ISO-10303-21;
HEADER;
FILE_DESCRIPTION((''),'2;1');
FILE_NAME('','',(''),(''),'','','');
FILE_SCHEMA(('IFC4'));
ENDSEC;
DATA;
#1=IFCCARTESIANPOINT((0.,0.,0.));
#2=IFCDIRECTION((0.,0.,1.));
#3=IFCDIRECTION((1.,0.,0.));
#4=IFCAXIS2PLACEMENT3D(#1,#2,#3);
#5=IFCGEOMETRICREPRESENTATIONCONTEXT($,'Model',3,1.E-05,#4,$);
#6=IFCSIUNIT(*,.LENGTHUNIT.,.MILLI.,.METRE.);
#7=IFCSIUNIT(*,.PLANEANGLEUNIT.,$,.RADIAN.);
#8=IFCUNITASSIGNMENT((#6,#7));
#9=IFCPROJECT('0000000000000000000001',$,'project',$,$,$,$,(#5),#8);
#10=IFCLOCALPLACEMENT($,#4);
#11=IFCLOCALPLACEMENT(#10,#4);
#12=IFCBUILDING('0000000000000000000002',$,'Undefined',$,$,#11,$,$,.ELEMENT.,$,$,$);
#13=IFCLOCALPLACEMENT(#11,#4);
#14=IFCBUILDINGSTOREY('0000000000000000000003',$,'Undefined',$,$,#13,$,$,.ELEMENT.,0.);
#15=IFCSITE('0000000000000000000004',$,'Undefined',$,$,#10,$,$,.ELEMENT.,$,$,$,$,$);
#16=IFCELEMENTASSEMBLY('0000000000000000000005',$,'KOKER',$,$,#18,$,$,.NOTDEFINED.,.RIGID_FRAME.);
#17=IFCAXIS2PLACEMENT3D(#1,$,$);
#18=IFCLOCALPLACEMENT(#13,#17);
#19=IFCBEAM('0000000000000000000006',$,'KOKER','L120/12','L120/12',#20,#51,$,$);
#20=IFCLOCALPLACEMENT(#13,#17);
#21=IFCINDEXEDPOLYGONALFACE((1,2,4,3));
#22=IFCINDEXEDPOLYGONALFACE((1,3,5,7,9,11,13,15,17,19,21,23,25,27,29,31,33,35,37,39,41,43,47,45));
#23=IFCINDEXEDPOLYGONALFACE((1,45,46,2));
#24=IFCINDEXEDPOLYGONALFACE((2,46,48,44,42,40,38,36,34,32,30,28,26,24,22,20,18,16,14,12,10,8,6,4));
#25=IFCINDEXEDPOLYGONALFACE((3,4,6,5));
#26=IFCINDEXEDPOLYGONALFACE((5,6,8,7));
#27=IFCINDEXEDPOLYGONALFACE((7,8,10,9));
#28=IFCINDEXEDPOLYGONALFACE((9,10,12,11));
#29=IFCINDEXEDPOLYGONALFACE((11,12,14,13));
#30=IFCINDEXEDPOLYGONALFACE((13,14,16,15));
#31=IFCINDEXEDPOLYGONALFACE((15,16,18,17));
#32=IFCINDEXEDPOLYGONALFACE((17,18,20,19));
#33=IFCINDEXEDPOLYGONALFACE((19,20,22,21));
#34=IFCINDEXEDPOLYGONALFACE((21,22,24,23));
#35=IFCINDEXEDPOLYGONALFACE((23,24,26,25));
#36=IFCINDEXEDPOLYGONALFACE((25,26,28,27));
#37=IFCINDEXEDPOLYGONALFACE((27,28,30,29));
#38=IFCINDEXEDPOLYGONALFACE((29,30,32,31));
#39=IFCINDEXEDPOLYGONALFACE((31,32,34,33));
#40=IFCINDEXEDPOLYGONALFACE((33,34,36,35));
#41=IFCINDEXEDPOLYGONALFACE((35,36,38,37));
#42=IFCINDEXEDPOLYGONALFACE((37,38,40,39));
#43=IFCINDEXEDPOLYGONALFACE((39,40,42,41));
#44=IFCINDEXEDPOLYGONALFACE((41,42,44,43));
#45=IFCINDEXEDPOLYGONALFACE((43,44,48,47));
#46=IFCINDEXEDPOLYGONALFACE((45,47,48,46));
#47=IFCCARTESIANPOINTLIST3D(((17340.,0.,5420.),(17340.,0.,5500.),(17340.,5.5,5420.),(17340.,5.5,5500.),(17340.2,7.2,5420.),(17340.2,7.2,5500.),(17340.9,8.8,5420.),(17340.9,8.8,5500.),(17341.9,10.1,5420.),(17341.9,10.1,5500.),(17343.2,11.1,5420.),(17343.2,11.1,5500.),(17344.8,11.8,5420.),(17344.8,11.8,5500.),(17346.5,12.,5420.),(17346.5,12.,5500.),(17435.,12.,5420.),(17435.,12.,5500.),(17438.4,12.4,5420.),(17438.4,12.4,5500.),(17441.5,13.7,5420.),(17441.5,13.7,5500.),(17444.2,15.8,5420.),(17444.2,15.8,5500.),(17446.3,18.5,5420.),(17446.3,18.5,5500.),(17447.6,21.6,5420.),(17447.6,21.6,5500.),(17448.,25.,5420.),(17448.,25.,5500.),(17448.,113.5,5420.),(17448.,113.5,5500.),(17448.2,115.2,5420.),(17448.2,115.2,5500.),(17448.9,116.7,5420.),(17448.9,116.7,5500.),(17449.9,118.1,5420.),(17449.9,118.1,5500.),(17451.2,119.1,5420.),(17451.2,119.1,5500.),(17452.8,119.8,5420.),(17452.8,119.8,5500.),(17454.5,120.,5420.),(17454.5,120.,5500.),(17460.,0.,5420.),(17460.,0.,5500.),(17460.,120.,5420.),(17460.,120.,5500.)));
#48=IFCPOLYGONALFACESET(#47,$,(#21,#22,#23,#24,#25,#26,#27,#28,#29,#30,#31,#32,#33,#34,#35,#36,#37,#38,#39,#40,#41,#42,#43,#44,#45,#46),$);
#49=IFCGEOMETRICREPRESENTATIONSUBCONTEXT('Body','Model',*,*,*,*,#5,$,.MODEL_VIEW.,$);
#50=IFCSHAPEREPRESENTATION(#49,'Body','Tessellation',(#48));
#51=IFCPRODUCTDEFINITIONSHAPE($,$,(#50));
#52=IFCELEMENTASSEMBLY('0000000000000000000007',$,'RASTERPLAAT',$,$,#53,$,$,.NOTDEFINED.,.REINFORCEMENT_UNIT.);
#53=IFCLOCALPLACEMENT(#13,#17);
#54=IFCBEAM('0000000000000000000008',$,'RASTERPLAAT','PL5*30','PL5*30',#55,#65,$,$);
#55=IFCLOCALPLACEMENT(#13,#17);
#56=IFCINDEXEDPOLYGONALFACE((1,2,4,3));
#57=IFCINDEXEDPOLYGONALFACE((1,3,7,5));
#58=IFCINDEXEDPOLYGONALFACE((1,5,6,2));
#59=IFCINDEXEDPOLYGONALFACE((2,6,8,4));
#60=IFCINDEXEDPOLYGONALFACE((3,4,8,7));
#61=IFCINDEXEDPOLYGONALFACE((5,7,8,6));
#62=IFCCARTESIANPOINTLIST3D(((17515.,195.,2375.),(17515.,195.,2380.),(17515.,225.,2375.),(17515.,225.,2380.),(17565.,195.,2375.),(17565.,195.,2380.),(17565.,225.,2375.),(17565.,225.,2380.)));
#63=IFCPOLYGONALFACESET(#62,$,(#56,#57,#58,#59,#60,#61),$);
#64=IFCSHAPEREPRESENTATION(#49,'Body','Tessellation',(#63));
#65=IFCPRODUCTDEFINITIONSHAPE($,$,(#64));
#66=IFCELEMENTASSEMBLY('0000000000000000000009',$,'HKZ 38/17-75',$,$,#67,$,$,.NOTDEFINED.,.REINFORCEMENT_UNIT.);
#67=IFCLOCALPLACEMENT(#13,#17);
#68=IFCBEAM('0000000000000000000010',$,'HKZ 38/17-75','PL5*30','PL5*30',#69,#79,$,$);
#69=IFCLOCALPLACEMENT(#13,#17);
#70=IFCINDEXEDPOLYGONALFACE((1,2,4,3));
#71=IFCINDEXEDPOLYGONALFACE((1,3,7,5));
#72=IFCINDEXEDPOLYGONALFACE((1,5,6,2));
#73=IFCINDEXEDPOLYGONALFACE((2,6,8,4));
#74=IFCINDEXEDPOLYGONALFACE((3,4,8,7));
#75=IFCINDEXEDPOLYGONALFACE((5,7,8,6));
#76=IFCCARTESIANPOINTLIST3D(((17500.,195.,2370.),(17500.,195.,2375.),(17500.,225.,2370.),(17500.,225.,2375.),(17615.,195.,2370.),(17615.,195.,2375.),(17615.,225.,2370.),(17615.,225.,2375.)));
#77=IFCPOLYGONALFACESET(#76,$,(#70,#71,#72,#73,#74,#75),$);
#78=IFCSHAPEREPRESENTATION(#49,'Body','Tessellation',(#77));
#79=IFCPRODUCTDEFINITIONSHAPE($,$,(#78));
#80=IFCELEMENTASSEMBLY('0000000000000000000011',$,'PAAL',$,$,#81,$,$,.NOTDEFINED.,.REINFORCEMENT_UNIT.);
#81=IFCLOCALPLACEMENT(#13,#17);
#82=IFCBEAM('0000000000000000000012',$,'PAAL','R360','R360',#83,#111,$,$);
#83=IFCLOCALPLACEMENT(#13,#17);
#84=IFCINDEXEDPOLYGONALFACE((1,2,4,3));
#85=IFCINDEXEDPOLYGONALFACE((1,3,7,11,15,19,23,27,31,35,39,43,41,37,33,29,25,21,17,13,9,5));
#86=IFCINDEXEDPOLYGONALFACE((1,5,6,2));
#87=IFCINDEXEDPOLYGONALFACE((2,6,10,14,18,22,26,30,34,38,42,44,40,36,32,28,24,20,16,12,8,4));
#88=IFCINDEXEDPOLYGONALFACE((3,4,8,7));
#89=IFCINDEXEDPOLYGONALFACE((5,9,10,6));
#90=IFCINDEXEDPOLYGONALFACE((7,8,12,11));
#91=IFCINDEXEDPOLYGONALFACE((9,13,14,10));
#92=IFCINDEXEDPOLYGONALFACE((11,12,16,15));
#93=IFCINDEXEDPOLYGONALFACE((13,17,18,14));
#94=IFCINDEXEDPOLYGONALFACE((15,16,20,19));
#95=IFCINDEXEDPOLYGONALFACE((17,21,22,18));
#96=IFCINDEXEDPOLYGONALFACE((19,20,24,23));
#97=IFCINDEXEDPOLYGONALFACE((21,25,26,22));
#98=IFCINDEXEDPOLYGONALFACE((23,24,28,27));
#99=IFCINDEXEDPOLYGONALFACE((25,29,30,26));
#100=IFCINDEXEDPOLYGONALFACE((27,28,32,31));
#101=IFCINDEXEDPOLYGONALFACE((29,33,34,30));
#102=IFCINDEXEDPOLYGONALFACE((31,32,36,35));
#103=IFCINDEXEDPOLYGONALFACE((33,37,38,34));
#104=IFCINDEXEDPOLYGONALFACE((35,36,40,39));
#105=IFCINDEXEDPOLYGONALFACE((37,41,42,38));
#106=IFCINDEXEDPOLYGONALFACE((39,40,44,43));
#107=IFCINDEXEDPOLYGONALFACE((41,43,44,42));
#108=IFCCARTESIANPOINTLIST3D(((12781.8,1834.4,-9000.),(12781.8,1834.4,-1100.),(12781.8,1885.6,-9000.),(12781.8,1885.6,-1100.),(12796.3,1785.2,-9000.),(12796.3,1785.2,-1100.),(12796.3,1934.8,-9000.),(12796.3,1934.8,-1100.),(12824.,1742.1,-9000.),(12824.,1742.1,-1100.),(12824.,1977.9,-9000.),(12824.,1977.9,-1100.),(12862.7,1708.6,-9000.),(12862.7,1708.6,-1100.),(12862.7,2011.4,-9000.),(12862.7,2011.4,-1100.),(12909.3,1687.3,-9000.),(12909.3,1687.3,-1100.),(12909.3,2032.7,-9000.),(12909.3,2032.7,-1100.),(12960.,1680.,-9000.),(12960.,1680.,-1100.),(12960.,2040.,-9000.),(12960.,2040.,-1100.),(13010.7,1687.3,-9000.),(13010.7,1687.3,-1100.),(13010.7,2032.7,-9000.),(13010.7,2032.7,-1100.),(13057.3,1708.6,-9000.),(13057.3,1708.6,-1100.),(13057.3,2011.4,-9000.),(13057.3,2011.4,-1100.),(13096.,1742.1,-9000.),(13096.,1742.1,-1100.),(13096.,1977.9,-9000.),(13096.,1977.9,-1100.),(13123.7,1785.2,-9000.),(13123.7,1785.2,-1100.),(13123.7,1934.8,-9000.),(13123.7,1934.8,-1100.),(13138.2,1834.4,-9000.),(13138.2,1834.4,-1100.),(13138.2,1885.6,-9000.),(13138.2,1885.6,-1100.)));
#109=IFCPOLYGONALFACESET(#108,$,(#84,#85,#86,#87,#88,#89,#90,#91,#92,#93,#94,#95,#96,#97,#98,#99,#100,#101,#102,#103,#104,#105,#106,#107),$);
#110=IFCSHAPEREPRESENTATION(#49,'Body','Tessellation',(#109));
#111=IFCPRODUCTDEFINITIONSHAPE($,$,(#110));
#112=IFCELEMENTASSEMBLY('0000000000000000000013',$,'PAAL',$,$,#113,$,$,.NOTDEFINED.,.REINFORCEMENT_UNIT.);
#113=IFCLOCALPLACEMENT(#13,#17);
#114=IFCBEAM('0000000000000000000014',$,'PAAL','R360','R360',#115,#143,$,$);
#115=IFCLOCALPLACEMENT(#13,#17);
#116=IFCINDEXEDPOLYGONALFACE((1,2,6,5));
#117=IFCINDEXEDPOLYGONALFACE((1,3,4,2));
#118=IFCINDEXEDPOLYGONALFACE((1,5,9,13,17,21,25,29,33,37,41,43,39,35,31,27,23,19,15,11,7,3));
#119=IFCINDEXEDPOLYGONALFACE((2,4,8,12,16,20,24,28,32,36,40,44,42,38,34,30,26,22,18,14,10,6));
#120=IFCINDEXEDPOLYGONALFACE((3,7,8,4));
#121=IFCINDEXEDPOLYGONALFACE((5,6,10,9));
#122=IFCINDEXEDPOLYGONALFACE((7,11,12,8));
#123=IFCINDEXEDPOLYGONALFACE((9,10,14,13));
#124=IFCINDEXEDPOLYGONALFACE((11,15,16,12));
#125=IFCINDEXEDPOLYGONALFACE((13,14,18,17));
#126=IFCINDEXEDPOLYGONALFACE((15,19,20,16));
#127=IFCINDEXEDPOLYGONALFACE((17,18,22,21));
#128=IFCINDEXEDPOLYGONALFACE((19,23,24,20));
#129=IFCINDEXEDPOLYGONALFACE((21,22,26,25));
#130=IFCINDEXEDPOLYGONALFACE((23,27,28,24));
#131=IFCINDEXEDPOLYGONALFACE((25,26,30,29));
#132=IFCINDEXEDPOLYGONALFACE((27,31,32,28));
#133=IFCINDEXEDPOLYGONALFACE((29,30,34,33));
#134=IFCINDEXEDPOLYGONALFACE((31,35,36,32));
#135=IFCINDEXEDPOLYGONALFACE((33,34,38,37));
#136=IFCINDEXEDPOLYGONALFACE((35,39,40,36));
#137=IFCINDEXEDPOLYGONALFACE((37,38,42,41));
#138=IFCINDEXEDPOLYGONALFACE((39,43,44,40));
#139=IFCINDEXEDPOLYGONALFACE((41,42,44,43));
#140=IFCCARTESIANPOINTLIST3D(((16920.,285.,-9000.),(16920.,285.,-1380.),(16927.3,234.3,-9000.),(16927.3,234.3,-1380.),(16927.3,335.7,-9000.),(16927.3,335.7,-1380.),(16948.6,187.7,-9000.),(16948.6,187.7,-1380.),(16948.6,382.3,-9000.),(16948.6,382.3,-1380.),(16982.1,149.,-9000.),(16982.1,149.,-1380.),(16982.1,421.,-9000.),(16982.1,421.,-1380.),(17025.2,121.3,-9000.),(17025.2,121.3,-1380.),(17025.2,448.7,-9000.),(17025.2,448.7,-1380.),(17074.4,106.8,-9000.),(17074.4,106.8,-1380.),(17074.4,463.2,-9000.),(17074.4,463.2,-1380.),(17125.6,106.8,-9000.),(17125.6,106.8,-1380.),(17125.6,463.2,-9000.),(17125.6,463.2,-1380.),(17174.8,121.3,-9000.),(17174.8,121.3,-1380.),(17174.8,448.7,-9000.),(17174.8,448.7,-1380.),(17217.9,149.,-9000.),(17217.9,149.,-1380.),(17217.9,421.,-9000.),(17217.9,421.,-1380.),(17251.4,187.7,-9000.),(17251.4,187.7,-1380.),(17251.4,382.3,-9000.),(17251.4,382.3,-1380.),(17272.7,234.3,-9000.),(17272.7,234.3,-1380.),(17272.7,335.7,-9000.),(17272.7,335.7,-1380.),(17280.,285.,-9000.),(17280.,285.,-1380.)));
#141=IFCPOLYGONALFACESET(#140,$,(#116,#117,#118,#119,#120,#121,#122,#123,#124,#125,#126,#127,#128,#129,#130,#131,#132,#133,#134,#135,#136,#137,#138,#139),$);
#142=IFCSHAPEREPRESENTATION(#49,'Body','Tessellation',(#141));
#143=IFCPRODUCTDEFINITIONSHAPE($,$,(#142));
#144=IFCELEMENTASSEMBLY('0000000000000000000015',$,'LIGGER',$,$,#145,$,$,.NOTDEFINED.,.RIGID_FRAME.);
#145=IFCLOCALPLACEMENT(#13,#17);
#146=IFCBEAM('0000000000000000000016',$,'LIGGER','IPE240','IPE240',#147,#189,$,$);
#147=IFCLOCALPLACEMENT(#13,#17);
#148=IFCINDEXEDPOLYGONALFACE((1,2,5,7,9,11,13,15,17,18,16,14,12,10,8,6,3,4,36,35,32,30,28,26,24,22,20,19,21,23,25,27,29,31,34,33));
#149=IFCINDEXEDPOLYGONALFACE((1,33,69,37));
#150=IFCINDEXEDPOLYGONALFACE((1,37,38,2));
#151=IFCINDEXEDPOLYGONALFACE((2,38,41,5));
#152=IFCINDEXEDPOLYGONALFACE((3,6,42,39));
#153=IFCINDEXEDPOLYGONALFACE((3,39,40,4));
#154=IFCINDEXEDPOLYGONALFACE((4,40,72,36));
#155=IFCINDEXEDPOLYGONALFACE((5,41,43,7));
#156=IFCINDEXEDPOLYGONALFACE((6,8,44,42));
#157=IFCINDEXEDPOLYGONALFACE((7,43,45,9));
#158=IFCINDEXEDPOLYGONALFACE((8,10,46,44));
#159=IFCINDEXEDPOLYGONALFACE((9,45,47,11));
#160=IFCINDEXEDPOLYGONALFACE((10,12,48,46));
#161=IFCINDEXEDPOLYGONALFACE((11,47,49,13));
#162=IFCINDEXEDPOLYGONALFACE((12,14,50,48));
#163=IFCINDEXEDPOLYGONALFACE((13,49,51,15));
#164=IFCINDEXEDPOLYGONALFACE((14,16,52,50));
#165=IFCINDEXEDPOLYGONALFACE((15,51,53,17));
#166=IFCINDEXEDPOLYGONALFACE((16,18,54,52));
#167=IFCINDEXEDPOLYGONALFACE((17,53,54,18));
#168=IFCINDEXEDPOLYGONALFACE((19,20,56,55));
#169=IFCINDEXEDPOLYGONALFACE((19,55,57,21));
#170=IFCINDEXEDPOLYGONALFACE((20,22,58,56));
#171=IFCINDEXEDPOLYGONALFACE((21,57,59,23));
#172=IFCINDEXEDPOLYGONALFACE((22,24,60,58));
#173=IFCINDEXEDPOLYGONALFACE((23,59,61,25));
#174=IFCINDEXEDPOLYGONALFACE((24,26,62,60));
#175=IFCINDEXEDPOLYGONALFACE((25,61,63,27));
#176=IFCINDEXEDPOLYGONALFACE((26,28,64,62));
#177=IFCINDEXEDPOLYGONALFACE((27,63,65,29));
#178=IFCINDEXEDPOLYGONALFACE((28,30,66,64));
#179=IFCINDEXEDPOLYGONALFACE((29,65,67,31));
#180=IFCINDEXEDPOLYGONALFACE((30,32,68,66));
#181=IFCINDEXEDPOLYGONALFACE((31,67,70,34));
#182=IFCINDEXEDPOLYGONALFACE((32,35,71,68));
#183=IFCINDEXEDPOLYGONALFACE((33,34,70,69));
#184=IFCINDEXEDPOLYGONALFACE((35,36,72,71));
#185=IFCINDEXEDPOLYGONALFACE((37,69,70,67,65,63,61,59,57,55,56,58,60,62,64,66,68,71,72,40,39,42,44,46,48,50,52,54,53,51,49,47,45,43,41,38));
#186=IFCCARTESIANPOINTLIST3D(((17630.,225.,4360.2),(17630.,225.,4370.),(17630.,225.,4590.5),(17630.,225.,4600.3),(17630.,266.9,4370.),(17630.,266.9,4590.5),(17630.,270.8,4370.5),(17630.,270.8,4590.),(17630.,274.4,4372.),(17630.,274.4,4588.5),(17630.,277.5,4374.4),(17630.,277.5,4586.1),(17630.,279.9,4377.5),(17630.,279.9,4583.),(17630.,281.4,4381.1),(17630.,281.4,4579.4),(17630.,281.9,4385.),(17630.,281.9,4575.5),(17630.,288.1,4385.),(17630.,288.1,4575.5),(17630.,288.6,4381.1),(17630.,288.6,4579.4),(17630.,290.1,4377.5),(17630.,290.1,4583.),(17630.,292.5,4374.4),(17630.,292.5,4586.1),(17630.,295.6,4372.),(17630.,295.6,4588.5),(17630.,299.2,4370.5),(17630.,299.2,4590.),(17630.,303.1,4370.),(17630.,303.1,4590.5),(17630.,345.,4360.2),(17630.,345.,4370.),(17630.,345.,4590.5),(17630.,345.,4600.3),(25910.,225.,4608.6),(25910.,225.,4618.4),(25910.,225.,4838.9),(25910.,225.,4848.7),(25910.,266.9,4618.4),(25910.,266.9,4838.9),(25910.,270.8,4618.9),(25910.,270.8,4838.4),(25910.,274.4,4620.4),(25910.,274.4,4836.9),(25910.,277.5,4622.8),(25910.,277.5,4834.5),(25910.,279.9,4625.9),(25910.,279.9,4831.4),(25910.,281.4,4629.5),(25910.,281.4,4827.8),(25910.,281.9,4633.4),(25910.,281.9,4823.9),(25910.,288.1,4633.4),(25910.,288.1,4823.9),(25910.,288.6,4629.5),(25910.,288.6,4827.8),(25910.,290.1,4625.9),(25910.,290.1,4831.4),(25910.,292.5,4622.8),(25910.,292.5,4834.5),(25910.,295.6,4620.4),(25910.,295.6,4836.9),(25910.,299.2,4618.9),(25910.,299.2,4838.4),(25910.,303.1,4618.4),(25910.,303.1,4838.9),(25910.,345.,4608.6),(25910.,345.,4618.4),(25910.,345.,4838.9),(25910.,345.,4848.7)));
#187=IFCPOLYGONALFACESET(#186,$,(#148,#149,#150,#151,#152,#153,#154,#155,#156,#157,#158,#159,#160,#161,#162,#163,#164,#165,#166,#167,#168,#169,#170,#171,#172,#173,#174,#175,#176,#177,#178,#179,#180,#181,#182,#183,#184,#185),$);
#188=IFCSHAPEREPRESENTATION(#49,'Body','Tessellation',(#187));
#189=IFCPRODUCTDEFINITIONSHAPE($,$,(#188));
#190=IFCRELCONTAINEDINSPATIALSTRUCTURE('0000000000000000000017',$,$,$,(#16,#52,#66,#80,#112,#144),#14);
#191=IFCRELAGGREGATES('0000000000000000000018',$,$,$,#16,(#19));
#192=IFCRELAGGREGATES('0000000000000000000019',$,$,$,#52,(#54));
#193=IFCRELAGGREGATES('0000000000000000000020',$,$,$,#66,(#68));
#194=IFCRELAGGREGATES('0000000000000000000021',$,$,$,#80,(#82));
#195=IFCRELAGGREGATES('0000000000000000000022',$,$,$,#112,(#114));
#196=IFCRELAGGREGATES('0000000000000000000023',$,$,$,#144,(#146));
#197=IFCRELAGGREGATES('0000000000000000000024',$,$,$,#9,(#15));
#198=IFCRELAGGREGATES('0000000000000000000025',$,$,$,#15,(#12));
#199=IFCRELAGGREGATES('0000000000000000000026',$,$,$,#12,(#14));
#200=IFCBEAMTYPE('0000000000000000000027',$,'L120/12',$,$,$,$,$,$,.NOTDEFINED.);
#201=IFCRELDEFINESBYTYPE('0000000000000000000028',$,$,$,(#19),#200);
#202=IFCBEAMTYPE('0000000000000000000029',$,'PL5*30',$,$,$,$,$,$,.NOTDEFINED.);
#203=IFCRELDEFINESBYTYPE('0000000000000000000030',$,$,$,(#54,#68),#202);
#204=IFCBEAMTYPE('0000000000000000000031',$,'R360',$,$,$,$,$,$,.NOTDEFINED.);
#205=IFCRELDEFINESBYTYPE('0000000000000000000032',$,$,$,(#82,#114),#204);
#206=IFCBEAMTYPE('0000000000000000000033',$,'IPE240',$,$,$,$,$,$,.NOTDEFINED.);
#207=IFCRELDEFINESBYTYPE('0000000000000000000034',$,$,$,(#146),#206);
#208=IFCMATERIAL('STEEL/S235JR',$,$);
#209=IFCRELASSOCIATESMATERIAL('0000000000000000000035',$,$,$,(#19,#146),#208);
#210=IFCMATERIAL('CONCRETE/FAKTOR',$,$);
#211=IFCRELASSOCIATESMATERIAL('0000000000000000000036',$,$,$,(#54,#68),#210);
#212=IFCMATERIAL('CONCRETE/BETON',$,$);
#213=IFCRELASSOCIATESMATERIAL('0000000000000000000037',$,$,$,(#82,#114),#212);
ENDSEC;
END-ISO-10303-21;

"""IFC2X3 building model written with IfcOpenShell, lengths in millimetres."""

from ifc_helpers import new_model, si_unit, frame, frame_2d, origin_with_axes, place, context, subcontext, project, spatial, rectangle, circle, i_section, l_section, extrude, clip, halfspace, material, type_object, element, aggregate, save


model = new_model("IFC2X3")

# Units and contexts
model_context = context("Model", 3, precision=1e-05, world=origin_with_axes())
body_context = subcontext(model_context, "Body", "Model", "MODEL_VIEW")
ifc_project = project(units=[si_unit("LENGTHUNIT", "METRE", prefix="MILLI"), si_unit("PLANEANGLEUNIT", "RADIAN")], contexts=[model_context])

# Site, building, storey
site_placement = place(None, origin_with_axes())
site = spatial("IfcSite", under=ifc_project, at=site_placement, Name="Undefined", CompositionType="ELEMENT")
building_placement = place(site_placement, origin_with_axes())
building = spatial("IfcBuilding", under=site, at=building_placement, Name="Undefined", CompositionType="ELEMENT")
storey_placement = place(building_placement, origin_with_axes())
storey = spatial("IfcBuildingStorey", under=building, at=storey_placement, Name="Undefined", CompositionType="ELEMENT", Elevation=0.0)

# Shared definitions
ifc_material_1 = material(Name="CONCRETE/BETON")

# Element assemblies, beams
ifc_material_2 = material(Name="STEEL/S235JR")
beam_type_1 = type_object("IfcBeamType", Name="L120/12", PredefinedType="NOTDEFINED")
assembly_1_placement = place(storey_placement, origin_with_axes())
assembly_1 = element("IfcElementAssembly", 1, at=assembly_1_placement, inside=storey, Name="KOKER", AssemblyPlace="NOTDEFINED", PredefinedType="RIGID_FRAME")
beam_1_placement = place(assembly_1_placement, frame((17400.0, 60.0, 5500.0), z_axis=(-1.0, 0.0, 0.0), x_axis=(0.0, 0.0, -1.0)))
beam_1 = element("IfcBeam", 2, at=beam_1_placement, type_object=beam_type_1, material=ifc_material_2, Name="KOKER", Description="L120/12", ObjectType="L120/12", context=body_context, shape_type="SweptSolid", body=[
    extrude(l_section(Depth=120.0, Width=120.0, Thickness=12.0, FilletRadius=13.0, EdgeRadius=6.5, at=frame_2d((0.0, 0.0), x_axis=(1.0, 0.0))), frame((80.0, 0.0, 0.0), z_axis=(-1.0, 0.0, 0.0), x_axis=(0.0, -1.0, 0.0)), (0.0, 0.0, 1.0), 80.0),
])
aggregate(assembly_1, [beam_1])
assembly_2_placement = place(storey_placement, origin_with_axes())
assembly_2 = element("IfcElementAssembly", 3, at=assembly_2_placement, inside=storey, Name="RASTERPLAAT", AssemblyPlace="NOTDEFINED", PredefinedType="REINFORCEMENT_UNIT")
ifc_material_3 = material(Name="CONCRETE/FAKTOR")
beam_type_2 = type_object("IfcBeamType", Name="PL5*30", PredefinedType="NOTDEFINED")
beam_2_placement = place(assembly_2_placement, frame((17565.0, 210.0, 2377.5), z_axis=(0.0, -1.0, 0.0), x_axis=(-1.0, 0.0, 0.0)))
beam_2 = element("IfcBeam", 4, at=beam_2_placement, type_object=beam_type_2, material=ifc_material_3, Name="RASTERPLAAT", Description="PL5*30", ObjectType="PL5*30", context=body_context, shape_type="SweptSolid", body=[
    extrude(rectangle(XDim=5.0, YDim=30.0, at=frame_2d((0.0, 0.0), x_axis=(1.0, 0.0))), frame((50.0, 0.0, 0.0), z_axis=(-1.0, 0.0, 0.0), x_axis=(0.0, -1.0, 0.0)), (0.0, 0.0, 1.0), 50.0),
])
aggregate(assembly_2, [beam_2])
assembly_3_placement = place(storey_placement, origin_with_axes())
assembly_3 = element("IfcElementAssembly", 5, at=assembly_3_placement, inside=storey, Name="HKZ 38/17-75", AssemblyPlace="NOTDEFINED", PredefinedType="REINFORCEMENT_UNIT")
beam_3_placement = place(assembly_3_placement, frame((17615.0, 210.0, 2372.5), z_axis=(0.0, -1.0, 0.0), x_axis=(-1.0, 0.0, 0.0)))
beam_3 = element("IfcBeam", 6, at=beam_3_placement, type_object=beam_type_2, material=ifc_material_3, Name="HKZ 38/17-75", Description="PL5*30", ObjectType="PL5*30", context=body_context, shape_type="SweptSolid", body=[
    extrude(rectangle(XDim=5.0, YDim=30.0, at=frame_2d((0.0, 0.0), x_axis=(1.0, 0.0))), frame((115.0, 0.0, 0.0), z_axis=(-1.0, 0.0, 0.0), x_axis=(0.0, -1.0, 0.0)), (0.0, 0.0, 1.0), 115.0),
])
aggregate(assembly_3, [beam_3])
assembly_4_placement = place(storey_placement, origin_with_axes())
assembly_4 = element("IfcElementAssembly", 7, at=assembly_4_placement, inside=storey, Name="PAAL", AssemblyPlace="NOTDEFINED", PredefinedType="REINFORCEMENT_UNIT")
beam_type_3 = type_object("IfcBeamType", Name="R360", PredefinedType="NOTDEFINED")
beam_4_placement = place(assembly_4_placement, frame((12960.0, 1860.0, -1100.0), z_axis=(-1.0, 0.0, 0.0), x_axis=(0.0, 0.0, -1.0)))
beam_4 = element("IfcBeam", 8, at=beam_4_placement, type_object=beam_type_3, material=ifc_material_1, Name="PAAL", Description="R360", ObjectType="R360", context=body_context, shape_type="SweptSolid", body=[
    extrude(circle(Radius=180.0, at=frame_2d((0.0, 0.0), x_axis=(1.0, 0.0))), frame((7900.0, 0.0, 0.0), z_axis=(-1.0, 0.0, 0.0), x_axis=(0.0, -1.0, 0.0)), (0.0, 0.0, 1.0), 7900.0),
])
aggregate(assembly_4, [beam_4])
assembly_5_placement = place(storey_placement, origin_with_axes())
assembly_5 = element("IfcElementAssembly", 9, at=assembly_5_placement, inside=storey, Name="PAAL", AssemblyPlace="NOTDEFINED", PredefinedType="REINFORCEMENT_UNIT")
beam_5_placement = place(assembly_5_placement, frame((17100.0, 285.0, -1380.0), z_axis=(0.0, -1.0, 0.0), x_axis=(0.0, 0.0, -1.0)))
beam_5 = element("IfcBeam", 10, at=beam_5_placement, type_object=beam_type_3, material=ifc_material_1, Name="PAAL", Description="R360", ObjectType="R360", context=body_context, shape_type="SweptSolid", body=[
    extrude(circle(Radius=180.0, at=frame_2d((0.0, 0.0), x_axis=(1.0, 0.0))), frame((7620.0, 0.0, 0.0), z_axis=(-1.0, 0.0, 0.0), x_axis=(0.0, -1.0, 0.0)), (0.0, 0.0, 1.0), 7620.0),
])
aggregate(assembly_5, [beam_5])
assembly_6_placement = place(storey_placement, origin_with_axes())
assembly_6 = element("IfcElementAssembly", 11, at=assembly_6_placement, inside=storey, Name="LIGGER", AssemblyPlace="NOTDEFINED", PredefinedType="RIGID_FRAME")
beam_type_4 = type_object("IfcBeamType", Name="IPE240", PredefinedType="NOTDEFINED")
beam_6_placement = place(assembly_6_placement, frame((17623.6, 285.0, 4480.1), z_axis=(-0.029987, 0.0, 0.99955), x_axis=(0.99955, 0.0, 0.029986)))
beam_6 = element("IfcBeam", 12, at=beam_6_placement, type_object=beam_type_4, material=ifc_material_2, Name="LIGGER", Description="IPE240", ObjectType="IPE240", context=body_context, shape_type="Clipping", body=[
    clip(clip(extrude(i_section(OverallWidth=120.0, OverallDepth=240.0, WebThickness=6.2, FlangeThickness=9.8, FilletRadius=15.0, at=frame_2d((0.0, 0.0), x_axis=(1.0, 0.0))), frame((8297.4, 0.0, 0.0), z_axis=(-1.0, 0.0, 0.0), x_axis=(0.0, -1.0, 0.0)), (0.0, 0.0, 1.0), 8298.2), halfspace(frame((8289.2, 0.0, -28.5), z_axis=(-0.99955, 0.0, 0.029987), x_axis=(0.0, -1.0, 0.0)), True)), halfspace(frame((2.8, 0.0, -120.0), z_axis=(0.99955, 0.0, -0.029987), x_axis=(0.0, -1.0, 0.0)), True)),
])
aggregate(assembly_6, [beam_6])

save(model, "model.ifc")
